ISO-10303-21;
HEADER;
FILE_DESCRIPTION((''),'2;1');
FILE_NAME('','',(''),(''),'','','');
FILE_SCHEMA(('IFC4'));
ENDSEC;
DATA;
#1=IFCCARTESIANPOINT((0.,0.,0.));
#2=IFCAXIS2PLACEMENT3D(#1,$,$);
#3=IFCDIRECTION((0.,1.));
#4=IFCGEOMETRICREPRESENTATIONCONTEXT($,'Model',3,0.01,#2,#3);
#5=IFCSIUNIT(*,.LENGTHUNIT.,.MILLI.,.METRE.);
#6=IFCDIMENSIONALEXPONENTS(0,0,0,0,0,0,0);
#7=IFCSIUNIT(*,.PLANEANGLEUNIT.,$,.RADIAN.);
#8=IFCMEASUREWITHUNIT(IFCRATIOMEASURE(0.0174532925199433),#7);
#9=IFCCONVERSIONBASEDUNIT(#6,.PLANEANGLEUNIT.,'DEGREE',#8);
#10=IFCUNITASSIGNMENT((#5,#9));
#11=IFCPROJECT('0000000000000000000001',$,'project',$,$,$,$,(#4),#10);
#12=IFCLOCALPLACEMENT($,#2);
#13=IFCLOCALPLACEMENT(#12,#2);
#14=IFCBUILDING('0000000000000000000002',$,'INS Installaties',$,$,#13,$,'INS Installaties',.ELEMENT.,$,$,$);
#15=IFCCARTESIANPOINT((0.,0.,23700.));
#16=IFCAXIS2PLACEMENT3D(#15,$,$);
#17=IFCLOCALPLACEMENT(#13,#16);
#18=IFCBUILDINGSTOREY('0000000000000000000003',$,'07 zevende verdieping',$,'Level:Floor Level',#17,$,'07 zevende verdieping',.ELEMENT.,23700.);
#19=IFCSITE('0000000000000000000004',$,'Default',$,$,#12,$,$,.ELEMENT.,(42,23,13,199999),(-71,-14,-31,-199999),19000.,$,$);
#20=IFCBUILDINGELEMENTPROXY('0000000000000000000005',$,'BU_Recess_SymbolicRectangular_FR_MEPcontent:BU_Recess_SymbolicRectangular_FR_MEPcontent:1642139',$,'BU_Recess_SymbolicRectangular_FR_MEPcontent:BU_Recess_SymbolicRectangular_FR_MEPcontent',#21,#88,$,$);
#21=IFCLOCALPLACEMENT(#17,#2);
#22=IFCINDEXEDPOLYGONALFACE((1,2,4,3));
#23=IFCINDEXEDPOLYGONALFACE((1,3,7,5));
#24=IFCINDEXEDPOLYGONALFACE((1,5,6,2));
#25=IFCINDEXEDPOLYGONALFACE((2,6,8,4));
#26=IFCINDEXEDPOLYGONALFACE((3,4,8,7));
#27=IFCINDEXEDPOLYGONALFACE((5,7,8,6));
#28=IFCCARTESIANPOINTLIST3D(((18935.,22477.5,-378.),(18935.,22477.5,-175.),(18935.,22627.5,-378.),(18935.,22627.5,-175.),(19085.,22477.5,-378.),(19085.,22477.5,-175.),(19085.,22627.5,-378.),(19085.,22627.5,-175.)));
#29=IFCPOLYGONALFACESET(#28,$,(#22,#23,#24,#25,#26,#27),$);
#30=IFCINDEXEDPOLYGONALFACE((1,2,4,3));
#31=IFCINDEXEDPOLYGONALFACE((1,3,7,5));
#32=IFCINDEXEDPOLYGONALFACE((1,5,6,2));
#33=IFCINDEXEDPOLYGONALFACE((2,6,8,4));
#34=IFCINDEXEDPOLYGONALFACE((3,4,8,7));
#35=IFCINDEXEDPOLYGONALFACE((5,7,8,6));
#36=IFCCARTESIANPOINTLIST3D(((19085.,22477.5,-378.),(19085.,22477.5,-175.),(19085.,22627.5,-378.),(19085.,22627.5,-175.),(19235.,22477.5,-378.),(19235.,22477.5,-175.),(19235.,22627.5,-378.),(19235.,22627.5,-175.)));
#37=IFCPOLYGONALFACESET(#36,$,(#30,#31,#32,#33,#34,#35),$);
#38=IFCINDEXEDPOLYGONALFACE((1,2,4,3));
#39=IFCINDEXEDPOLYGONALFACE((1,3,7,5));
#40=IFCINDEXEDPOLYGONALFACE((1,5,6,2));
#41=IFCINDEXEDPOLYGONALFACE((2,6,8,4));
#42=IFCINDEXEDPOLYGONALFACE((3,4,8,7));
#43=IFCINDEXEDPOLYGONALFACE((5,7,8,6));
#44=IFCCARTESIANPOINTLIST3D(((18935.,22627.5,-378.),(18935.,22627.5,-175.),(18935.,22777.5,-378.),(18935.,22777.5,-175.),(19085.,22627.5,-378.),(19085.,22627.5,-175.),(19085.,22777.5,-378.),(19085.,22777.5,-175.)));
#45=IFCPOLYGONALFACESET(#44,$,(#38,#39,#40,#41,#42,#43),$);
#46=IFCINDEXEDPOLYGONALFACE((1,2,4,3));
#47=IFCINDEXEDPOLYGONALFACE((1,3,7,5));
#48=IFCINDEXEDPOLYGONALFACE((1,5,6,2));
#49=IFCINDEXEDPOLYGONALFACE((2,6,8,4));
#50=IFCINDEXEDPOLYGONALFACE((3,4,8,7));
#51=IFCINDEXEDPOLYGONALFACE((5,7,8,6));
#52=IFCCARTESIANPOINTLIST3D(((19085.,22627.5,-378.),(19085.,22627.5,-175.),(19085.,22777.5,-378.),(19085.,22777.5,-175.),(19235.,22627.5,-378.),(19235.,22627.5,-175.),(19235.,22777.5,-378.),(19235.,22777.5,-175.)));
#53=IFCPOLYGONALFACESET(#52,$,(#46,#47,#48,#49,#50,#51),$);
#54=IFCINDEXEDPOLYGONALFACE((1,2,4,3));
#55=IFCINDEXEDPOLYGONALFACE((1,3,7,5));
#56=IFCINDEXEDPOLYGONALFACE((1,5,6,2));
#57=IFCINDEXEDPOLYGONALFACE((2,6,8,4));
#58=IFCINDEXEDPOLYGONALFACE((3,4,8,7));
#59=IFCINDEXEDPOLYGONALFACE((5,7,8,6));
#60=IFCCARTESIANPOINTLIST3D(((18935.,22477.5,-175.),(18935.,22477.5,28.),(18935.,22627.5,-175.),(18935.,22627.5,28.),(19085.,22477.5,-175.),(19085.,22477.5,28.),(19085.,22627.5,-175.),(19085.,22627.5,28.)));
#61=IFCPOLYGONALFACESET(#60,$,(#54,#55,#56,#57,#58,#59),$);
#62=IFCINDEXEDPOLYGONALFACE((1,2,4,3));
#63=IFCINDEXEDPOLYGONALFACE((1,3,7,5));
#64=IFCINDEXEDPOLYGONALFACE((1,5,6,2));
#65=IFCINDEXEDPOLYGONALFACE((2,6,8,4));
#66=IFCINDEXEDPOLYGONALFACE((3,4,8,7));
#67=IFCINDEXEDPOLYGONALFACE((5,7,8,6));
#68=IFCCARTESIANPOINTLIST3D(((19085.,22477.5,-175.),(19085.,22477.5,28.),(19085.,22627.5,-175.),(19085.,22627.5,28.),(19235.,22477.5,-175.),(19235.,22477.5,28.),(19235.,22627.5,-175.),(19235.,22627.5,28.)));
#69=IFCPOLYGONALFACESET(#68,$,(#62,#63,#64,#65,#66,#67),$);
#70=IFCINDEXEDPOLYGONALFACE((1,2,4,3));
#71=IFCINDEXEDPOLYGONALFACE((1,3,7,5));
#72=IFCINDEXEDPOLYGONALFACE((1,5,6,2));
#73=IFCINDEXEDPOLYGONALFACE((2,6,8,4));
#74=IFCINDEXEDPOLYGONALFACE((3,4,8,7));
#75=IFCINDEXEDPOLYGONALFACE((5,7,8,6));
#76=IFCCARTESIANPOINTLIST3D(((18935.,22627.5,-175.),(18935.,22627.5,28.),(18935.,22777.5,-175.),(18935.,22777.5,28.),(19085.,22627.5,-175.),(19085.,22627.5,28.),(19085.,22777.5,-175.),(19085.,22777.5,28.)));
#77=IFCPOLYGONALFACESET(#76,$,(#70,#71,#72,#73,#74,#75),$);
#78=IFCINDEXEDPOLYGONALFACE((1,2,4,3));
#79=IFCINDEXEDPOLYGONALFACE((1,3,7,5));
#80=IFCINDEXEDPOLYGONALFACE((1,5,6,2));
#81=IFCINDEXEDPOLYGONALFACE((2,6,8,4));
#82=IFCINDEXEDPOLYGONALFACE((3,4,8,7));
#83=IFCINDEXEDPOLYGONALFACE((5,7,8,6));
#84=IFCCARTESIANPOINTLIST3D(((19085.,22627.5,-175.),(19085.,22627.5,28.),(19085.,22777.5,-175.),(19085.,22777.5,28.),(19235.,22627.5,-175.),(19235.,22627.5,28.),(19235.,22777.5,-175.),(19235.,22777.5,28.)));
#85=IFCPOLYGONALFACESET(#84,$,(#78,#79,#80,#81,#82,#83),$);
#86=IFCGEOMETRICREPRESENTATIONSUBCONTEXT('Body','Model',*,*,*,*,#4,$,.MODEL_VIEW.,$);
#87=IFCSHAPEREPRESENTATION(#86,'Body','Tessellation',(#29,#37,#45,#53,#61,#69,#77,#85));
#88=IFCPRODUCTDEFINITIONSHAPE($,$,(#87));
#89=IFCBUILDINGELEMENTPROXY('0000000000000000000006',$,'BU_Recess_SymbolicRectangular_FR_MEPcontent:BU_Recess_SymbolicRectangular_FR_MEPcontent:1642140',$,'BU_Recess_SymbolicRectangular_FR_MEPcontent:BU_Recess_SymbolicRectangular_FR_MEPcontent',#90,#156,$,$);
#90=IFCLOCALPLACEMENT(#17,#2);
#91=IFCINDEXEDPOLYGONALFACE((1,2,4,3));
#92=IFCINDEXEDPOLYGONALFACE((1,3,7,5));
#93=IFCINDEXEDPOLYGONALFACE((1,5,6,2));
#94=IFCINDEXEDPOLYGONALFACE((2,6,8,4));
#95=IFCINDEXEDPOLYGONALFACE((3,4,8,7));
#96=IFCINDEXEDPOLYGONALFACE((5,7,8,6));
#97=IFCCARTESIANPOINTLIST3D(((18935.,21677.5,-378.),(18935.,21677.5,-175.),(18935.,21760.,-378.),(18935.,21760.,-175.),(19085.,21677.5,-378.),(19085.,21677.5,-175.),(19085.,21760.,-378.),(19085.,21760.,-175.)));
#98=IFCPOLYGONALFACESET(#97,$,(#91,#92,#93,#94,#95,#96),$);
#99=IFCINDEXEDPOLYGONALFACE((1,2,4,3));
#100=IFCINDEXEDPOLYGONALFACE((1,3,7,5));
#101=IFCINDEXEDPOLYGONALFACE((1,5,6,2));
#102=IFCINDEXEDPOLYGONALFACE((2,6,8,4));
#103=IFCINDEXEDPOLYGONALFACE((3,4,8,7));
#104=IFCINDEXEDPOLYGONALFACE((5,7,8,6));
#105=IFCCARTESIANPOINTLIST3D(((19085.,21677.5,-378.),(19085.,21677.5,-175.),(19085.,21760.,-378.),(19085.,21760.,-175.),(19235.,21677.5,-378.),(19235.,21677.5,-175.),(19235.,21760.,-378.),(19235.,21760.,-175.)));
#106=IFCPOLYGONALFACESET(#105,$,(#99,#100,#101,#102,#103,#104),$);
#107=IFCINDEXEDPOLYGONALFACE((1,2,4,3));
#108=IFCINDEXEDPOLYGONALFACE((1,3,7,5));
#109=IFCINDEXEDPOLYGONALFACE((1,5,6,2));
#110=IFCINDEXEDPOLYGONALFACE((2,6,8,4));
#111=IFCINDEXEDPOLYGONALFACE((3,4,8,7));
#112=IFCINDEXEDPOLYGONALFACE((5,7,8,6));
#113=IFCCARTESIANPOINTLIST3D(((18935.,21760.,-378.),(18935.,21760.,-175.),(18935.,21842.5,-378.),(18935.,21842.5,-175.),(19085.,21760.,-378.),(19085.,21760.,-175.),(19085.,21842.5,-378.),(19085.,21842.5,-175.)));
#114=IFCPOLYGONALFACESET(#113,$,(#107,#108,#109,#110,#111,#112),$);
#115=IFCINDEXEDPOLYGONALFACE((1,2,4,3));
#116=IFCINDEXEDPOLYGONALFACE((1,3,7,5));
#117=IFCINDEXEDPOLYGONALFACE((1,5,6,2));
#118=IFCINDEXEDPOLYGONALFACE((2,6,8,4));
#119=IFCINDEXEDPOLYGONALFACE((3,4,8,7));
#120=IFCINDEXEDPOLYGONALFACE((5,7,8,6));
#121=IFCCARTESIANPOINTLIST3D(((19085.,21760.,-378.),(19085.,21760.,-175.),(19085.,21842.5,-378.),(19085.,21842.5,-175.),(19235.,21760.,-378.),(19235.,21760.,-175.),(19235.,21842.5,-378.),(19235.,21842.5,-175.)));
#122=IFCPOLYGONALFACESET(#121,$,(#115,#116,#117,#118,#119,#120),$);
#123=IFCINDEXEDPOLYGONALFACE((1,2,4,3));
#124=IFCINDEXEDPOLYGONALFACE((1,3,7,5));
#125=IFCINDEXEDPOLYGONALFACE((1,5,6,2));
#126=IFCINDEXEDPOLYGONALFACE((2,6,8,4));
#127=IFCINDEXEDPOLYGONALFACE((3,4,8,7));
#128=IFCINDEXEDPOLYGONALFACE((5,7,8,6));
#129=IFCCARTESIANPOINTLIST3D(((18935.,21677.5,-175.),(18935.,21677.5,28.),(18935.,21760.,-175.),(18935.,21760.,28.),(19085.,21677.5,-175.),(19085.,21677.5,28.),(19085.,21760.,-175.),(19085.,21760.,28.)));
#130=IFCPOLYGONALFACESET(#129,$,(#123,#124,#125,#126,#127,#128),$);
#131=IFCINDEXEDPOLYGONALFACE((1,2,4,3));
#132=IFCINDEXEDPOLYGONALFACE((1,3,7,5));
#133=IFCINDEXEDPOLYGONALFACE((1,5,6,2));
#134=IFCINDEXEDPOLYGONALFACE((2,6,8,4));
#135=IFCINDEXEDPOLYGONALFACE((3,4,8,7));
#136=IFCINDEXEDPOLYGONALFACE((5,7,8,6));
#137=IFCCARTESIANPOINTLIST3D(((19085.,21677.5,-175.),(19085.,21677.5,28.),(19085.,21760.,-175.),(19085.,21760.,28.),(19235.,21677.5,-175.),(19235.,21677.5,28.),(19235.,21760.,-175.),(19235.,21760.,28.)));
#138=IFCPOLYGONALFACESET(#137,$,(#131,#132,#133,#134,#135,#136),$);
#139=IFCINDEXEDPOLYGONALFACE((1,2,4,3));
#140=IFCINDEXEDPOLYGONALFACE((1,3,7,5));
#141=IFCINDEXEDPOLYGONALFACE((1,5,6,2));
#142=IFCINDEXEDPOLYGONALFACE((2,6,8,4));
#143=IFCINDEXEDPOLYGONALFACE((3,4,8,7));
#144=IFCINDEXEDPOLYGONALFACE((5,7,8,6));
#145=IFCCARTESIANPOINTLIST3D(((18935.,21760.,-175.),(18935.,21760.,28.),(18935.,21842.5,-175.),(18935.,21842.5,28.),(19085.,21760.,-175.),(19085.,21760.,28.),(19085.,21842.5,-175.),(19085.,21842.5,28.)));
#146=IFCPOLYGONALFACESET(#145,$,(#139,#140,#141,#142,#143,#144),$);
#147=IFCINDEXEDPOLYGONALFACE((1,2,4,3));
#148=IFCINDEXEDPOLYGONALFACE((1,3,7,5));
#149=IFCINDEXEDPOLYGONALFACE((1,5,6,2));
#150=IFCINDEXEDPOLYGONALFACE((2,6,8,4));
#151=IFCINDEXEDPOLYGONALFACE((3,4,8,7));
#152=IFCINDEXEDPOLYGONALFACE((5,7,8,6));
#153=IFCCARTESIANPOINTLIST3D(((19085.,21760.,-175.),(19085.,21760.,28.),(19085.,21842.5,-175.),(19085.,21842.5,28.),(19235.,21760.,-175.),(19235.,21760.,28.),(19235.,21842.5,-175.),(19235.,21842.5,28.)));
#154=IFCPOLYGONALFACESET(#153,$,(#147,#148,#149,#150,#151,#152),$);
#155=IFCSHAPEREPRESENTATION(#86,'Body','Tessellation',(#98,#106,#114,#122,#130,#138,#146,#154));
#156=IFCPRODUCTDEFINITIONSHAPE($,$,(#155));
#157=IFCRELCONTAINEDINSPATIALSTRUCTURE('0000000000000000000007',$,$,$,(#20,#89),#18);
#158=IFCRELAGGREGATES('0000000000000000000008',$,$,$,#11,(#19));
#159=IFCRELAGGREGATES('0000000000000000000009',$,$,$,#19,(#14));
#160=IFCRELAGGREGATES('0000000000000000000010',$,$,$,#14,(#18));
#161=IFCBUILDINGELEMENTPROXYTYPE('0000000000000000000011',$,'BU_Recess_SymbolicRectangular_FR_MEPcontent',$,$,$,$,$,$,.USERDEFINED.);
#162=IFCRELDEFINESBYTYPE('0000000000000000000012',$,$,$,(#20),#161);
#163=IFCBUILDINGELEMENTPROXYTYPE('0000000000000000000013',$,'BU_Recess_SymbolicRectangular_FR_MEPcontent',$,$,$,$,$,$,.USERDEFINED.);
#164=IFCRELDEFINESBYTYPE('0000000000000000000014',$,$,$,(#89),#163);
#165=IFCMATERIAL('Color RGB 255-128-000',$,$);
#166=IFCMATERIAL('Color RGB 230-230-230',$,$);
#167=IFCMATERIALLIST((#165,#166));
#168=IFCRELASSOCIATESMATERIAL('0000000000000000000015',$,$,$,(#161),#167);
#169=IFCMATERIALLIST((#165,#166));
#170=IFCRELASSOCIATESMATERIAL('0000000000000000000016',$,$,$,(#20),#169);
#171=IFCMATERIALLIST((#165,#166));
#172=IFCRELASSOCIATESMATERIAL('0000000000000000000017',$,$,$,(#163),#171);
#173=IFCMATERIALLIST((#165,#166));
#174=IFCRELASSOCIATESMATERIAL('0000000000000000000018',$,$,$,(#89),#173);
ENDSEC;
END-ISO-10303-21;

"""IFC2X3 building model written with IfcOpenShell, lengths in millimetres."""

from ifc_helpers import new_model, entity, si_unit, converted_unit, direction, frame, frame_2d, origin, origin_2d_with_axis, place, context, subcontext, project, spatial, rectangle, extrude, source, transform, mapped, material, material_list, type_object, type_shapes, element, save


model = new_model("IFC2X3")

# Units and contexts
model_context = context("Model", 3, precision=0.01, world=origin(), true_north=direction((0.0, 1.0)))
body_context = subcontext(model_context, "Body", "Model", "MODEL_VIEW")
ifc_project = project(units=[si_unit("LENGTHUNIT", "METRE", prefix="MILLI"), converted_unit("PLANEANGLEUNIT", "DEGREE", entity("IfcRatioMeasure", 0.0174532925199433), si_unit("PLANEANGLEUNIT", "RADIAN"), dimensions=[0, 0, 0, 0, 0, 0, 0])], contexts=[model_context])

# Site, building, storey
site_placement = place(None, origin())
site = spatial("IfcSite", under=ifc_project, at=site_placement, Name="Default", CompositionType="ELEMENT", RefLatitude=(42, 23, 13, 199999), RefLongitude=(-71, -14, -31, -199999), RefElevation=19000.0)
building_placement = place(site_placement, origin())
building = spatial("IfcBuilding", under=site, at=building_placement, Name="INS Installaties", LongName="INS Installaties", CompositionType="ELEMENT")
storey_placement = place(building_placement, frame((0.0, 0.0, 23700.0)))
storey = spatial("IfcBuildingStorey", under=building, at=storey_placement, Name="07 zevende verdieping", ObjectType="Level:Floor Level", LongName="07 zevende verdieping", CompositionType="ELEMENT", Elevation=23700.0)

# Building element proxies
ifc_material_1 = material(Name="Color RGB 255-128-000")
ifc_material_2 = material(Name="Color RGB 230-230-230")
ifc_material_list_1 = material_list([ifc_material_1, ifc_material_2])
ifc_material_list_2 = material_list([ifc_material_1, ifc_material_2])
building_element_proxy_type_1 = type_object("IfcBuildingElementProxyType", Name="BU_Recess_SymbolicRectangular_FR_MEPcontent", PredefinedType="USERDEFINED", material=ifc_material_list_2)
shared_shape_1 = source(origin(), body_context, "Body", "SweptSolid", [
    extrude(rectangle(XDim=150.0, YDim=150.0, at=origin_2d_with_axis()), frame((75.0, 75.0, -403.0), z_axis=(0.0, 0.0, 1.0), x_axis=(0.0, -1.0, 0.0)), (0.0, 0.0, 1.0), 203.0),
    extrude(rectangle(XDim=150.0, YDim=150.0, at=frame_2d((0.0, 0.0), x_axis=(1.0, 0.0))), frame((-75.0, 75.0, -403.0), z_axis=(0.0, 0.0, 1.0), x_axis=(-1.0, 0.0, 0.0)), (0.0, 0.0, 1.0), 203.0),
    extrude(rectangle(XDim=150.0, YDim=150.0, at=frame_2d((0.0, 0.0), x_axis=(1.0, 0.0))), frame((75.0, -75.0, -403.0)), (0.0, 0.0, 1.0), 203.0),
    extrude(rectangle(XDim=150.0, YDim=150.0, at=origin_2d_with_axis()), frame((-75.0, -75.0, -403.0), z_axis=(0.0, 0.0, 1.0), x_axis=(0.0, 1.0, 0.0)), (0.0, 0.0, 1.0), 203.0),
    extrude(rectangle(XDim=150.0, YDim=150.0, at=origin_2d_with_axis()), frame((75.0, 75.0, -200.0), z_axis=(0.0, 0.0, 1.0), x_axis=(0.0, -1.0, 0.0)), (0.0, 0.0, 1.0), 203.0),
    extrude(rectangle(XDim=150.0, YDim=150.0, at=frame_2d((0.0, 0.0), x_axis=(1.0, 0.0))), frame((-75.0, 75.0, -200.0), z_axis=(0.0, 0.0, 1.0), x_axis=(-1.0, 0.0, 0.0)), (0.0, 0.0, 1.0), 203.0),
    extrude(rectangle(XDim=150.0, YDim=150.0, at=frame_2d((0.0, 0.0), x_axis=(1.0, 0.0))), frame((75.0, -75.0, -200.0)), (0.0, 0.0, 1.0), 203.0),
    extrude(rectangle(XDim=150.0, YDim=150.0, at=origin_2d_with_axis()), frame((-75.0, -75.0, -200.0), z_axis=(0.0, 0.0, 1.0), x_axis=(0.0, 1.0, 0.0)), (0.0, 0.0, 1.0), 203.0),
])
type_shapes(building_element_proxy_type_1, [shared_shape_1])
proxy_1_placement = place(storey_placement, frame((19085.0, 22627.5, 25.0), z_axis=(0.0, 0.0, 1.0), x_axis=(-1.0, 0.0, 0.0)))
element("IfcBuildingElementProxy", 1, at=proxy_1_placement, inside=storey, type_object=building_element_proxy_type_1, material=ifc_material_list_1, Name="BU_Recess_SymbolicRectangular_FR_MEPcontent:BU_Recess_SymbolicRectangular_FR_MEPcontent:1642139", ObjectType="BU_Recess_SymbolicRectangular_FR_MEPcontent:BU_Recess_SymbolicRectangular_FR_MEPcontent", context=body_context, shape_type="MappedRepresentation", body=[
    mapped(shared_shape_1, transform((0.0, 0.0, 0.0), scale=1.0)),
])
ifc_material_list_3 = material_list([ifc_material_1, ifc_material_2])
ifc_material_list_4 = material_list([ifc_material_1, ifc_material_2])
building_element_proxy_type_2 = type_object("IfcBuildingElementProxyType", Name="BU_Recess_SymbolicRectangular_FR_MEPcontent", PredefinedType="USERDEFINED", material=ifc_material_list_4)
shared_shape_2 = source(origin(), body_context, "Body", "SweptSolid", [
    extrude(rectangle(XDim=82.5, YDim=150.0, at=origin_2d_with_axis()), frame((75.0, 41.2, -403.0), z_axis=(0.0, 0.0, 1.0), x_axis=(0.0, -1.0, 0.0)), (0.0, 0.0, 1.0), 203.0),
    extrude(rectangle(XDim=150.0, YDim=82.5, at=frame_2d((0.0, 0.0), x_axis=(1.0, 0.0))), frame((-75.0, 41.2, -403.0), z_axis=(0.0, 0.0, 1.0), x_axis=(-1.0, 0.0, 0.0)), (0.0, 0.0, 1.0), 203.0),
    extrude(rectangle(XDim=150.0, YDim=82.5, at=frame_2d((0.0, 0.0), x_axis=(1.0, 0.0))), frame((75.0, -41.3, -403.0)), (0.0, 0.0, 1.0), 203.0),
    extrude(rectangle(XDim=82.5, YDim=150.0, at=origin_2d_with_axis()), frame((-75.0, -41.3, -403.0), z_axis=(0.0, 0.0, 1.0), x_axis=(0.0, 1.0, 0.0)), (0.0, 0.0, 1.0), 203.0),
    extrude(rectangle(XDim=82.5, YDim=150.0, at=origin_2d_with_axis()), frame((75.0, 41.3, -200.0), z_axis=(0.0, 0.0, 1.0), x_axis=(0.0, -1.0, 0.0)), (0.0, 0.0, 1.0), 203.0),
    extrude(rectangle(XDim=150.0, YDim=82.5, at=frame_2d((0.0, 0.0), x_axis=(1.0, 0.0))), frame((-75.0, 41.3, -200.0), z_axis=(0.0, 0.0, 1.0), x_axis=(-1.0, 0.0, 0.0)), (0.0, 0.0, 1.0), 203.0),
    extrude(rectangle(XDim=150.0, YDim=82.5, at=frame_2d((0.0, 0.0), x_axis=(1.0, 0.0))), frame((75.0, -41.2, -200.0)), (0.0, 0.0, 1.0), 203.0),
    extrude(rectangle(XDim=82.5, YDim=150.0, at=origin_2d_with_axis()), frame((-75.0, -41.2, -200.0), z_axis=(0.0, 0.0, 1.0), x_axis=(0.0, 1.0, 0.0)), (0.0, 0.0, 1.0), 203.0),
])
type_shapes(building_element_proxy_type_2, [shared_shape_2])
proxy_2_placement = place(storey_placement, frame((19085.0, 21760.0, 25.0), z_axis=(0.0, 0.0, 1.0), x_axis=(-1.0, 0.0, 0.0)))
element("IfcBuildingElementProxy", 2, at=proxy_2_placement, inside=storey, type_object=building_element_proxy_type_2, material=ifc_material_list_3, Name="BU_Recess_SymbolicRectangular_FR_MEPcontent:BU_Recess_SymbolicRectangular_FR_MEPcontent:1642140", ObjectType="BU_Recess_SymbolicRectangular_FR_MEPcontent:BU_Recess_SymbolicRectangular_FR_MEPcontent", context=body_context, shape_type="MappedRepresentation", body=[
    mapped(shared_shape_2, transform((0.0, 0.0, 0.0), scale=1.0)),
])

save(model, "model.ifc")
